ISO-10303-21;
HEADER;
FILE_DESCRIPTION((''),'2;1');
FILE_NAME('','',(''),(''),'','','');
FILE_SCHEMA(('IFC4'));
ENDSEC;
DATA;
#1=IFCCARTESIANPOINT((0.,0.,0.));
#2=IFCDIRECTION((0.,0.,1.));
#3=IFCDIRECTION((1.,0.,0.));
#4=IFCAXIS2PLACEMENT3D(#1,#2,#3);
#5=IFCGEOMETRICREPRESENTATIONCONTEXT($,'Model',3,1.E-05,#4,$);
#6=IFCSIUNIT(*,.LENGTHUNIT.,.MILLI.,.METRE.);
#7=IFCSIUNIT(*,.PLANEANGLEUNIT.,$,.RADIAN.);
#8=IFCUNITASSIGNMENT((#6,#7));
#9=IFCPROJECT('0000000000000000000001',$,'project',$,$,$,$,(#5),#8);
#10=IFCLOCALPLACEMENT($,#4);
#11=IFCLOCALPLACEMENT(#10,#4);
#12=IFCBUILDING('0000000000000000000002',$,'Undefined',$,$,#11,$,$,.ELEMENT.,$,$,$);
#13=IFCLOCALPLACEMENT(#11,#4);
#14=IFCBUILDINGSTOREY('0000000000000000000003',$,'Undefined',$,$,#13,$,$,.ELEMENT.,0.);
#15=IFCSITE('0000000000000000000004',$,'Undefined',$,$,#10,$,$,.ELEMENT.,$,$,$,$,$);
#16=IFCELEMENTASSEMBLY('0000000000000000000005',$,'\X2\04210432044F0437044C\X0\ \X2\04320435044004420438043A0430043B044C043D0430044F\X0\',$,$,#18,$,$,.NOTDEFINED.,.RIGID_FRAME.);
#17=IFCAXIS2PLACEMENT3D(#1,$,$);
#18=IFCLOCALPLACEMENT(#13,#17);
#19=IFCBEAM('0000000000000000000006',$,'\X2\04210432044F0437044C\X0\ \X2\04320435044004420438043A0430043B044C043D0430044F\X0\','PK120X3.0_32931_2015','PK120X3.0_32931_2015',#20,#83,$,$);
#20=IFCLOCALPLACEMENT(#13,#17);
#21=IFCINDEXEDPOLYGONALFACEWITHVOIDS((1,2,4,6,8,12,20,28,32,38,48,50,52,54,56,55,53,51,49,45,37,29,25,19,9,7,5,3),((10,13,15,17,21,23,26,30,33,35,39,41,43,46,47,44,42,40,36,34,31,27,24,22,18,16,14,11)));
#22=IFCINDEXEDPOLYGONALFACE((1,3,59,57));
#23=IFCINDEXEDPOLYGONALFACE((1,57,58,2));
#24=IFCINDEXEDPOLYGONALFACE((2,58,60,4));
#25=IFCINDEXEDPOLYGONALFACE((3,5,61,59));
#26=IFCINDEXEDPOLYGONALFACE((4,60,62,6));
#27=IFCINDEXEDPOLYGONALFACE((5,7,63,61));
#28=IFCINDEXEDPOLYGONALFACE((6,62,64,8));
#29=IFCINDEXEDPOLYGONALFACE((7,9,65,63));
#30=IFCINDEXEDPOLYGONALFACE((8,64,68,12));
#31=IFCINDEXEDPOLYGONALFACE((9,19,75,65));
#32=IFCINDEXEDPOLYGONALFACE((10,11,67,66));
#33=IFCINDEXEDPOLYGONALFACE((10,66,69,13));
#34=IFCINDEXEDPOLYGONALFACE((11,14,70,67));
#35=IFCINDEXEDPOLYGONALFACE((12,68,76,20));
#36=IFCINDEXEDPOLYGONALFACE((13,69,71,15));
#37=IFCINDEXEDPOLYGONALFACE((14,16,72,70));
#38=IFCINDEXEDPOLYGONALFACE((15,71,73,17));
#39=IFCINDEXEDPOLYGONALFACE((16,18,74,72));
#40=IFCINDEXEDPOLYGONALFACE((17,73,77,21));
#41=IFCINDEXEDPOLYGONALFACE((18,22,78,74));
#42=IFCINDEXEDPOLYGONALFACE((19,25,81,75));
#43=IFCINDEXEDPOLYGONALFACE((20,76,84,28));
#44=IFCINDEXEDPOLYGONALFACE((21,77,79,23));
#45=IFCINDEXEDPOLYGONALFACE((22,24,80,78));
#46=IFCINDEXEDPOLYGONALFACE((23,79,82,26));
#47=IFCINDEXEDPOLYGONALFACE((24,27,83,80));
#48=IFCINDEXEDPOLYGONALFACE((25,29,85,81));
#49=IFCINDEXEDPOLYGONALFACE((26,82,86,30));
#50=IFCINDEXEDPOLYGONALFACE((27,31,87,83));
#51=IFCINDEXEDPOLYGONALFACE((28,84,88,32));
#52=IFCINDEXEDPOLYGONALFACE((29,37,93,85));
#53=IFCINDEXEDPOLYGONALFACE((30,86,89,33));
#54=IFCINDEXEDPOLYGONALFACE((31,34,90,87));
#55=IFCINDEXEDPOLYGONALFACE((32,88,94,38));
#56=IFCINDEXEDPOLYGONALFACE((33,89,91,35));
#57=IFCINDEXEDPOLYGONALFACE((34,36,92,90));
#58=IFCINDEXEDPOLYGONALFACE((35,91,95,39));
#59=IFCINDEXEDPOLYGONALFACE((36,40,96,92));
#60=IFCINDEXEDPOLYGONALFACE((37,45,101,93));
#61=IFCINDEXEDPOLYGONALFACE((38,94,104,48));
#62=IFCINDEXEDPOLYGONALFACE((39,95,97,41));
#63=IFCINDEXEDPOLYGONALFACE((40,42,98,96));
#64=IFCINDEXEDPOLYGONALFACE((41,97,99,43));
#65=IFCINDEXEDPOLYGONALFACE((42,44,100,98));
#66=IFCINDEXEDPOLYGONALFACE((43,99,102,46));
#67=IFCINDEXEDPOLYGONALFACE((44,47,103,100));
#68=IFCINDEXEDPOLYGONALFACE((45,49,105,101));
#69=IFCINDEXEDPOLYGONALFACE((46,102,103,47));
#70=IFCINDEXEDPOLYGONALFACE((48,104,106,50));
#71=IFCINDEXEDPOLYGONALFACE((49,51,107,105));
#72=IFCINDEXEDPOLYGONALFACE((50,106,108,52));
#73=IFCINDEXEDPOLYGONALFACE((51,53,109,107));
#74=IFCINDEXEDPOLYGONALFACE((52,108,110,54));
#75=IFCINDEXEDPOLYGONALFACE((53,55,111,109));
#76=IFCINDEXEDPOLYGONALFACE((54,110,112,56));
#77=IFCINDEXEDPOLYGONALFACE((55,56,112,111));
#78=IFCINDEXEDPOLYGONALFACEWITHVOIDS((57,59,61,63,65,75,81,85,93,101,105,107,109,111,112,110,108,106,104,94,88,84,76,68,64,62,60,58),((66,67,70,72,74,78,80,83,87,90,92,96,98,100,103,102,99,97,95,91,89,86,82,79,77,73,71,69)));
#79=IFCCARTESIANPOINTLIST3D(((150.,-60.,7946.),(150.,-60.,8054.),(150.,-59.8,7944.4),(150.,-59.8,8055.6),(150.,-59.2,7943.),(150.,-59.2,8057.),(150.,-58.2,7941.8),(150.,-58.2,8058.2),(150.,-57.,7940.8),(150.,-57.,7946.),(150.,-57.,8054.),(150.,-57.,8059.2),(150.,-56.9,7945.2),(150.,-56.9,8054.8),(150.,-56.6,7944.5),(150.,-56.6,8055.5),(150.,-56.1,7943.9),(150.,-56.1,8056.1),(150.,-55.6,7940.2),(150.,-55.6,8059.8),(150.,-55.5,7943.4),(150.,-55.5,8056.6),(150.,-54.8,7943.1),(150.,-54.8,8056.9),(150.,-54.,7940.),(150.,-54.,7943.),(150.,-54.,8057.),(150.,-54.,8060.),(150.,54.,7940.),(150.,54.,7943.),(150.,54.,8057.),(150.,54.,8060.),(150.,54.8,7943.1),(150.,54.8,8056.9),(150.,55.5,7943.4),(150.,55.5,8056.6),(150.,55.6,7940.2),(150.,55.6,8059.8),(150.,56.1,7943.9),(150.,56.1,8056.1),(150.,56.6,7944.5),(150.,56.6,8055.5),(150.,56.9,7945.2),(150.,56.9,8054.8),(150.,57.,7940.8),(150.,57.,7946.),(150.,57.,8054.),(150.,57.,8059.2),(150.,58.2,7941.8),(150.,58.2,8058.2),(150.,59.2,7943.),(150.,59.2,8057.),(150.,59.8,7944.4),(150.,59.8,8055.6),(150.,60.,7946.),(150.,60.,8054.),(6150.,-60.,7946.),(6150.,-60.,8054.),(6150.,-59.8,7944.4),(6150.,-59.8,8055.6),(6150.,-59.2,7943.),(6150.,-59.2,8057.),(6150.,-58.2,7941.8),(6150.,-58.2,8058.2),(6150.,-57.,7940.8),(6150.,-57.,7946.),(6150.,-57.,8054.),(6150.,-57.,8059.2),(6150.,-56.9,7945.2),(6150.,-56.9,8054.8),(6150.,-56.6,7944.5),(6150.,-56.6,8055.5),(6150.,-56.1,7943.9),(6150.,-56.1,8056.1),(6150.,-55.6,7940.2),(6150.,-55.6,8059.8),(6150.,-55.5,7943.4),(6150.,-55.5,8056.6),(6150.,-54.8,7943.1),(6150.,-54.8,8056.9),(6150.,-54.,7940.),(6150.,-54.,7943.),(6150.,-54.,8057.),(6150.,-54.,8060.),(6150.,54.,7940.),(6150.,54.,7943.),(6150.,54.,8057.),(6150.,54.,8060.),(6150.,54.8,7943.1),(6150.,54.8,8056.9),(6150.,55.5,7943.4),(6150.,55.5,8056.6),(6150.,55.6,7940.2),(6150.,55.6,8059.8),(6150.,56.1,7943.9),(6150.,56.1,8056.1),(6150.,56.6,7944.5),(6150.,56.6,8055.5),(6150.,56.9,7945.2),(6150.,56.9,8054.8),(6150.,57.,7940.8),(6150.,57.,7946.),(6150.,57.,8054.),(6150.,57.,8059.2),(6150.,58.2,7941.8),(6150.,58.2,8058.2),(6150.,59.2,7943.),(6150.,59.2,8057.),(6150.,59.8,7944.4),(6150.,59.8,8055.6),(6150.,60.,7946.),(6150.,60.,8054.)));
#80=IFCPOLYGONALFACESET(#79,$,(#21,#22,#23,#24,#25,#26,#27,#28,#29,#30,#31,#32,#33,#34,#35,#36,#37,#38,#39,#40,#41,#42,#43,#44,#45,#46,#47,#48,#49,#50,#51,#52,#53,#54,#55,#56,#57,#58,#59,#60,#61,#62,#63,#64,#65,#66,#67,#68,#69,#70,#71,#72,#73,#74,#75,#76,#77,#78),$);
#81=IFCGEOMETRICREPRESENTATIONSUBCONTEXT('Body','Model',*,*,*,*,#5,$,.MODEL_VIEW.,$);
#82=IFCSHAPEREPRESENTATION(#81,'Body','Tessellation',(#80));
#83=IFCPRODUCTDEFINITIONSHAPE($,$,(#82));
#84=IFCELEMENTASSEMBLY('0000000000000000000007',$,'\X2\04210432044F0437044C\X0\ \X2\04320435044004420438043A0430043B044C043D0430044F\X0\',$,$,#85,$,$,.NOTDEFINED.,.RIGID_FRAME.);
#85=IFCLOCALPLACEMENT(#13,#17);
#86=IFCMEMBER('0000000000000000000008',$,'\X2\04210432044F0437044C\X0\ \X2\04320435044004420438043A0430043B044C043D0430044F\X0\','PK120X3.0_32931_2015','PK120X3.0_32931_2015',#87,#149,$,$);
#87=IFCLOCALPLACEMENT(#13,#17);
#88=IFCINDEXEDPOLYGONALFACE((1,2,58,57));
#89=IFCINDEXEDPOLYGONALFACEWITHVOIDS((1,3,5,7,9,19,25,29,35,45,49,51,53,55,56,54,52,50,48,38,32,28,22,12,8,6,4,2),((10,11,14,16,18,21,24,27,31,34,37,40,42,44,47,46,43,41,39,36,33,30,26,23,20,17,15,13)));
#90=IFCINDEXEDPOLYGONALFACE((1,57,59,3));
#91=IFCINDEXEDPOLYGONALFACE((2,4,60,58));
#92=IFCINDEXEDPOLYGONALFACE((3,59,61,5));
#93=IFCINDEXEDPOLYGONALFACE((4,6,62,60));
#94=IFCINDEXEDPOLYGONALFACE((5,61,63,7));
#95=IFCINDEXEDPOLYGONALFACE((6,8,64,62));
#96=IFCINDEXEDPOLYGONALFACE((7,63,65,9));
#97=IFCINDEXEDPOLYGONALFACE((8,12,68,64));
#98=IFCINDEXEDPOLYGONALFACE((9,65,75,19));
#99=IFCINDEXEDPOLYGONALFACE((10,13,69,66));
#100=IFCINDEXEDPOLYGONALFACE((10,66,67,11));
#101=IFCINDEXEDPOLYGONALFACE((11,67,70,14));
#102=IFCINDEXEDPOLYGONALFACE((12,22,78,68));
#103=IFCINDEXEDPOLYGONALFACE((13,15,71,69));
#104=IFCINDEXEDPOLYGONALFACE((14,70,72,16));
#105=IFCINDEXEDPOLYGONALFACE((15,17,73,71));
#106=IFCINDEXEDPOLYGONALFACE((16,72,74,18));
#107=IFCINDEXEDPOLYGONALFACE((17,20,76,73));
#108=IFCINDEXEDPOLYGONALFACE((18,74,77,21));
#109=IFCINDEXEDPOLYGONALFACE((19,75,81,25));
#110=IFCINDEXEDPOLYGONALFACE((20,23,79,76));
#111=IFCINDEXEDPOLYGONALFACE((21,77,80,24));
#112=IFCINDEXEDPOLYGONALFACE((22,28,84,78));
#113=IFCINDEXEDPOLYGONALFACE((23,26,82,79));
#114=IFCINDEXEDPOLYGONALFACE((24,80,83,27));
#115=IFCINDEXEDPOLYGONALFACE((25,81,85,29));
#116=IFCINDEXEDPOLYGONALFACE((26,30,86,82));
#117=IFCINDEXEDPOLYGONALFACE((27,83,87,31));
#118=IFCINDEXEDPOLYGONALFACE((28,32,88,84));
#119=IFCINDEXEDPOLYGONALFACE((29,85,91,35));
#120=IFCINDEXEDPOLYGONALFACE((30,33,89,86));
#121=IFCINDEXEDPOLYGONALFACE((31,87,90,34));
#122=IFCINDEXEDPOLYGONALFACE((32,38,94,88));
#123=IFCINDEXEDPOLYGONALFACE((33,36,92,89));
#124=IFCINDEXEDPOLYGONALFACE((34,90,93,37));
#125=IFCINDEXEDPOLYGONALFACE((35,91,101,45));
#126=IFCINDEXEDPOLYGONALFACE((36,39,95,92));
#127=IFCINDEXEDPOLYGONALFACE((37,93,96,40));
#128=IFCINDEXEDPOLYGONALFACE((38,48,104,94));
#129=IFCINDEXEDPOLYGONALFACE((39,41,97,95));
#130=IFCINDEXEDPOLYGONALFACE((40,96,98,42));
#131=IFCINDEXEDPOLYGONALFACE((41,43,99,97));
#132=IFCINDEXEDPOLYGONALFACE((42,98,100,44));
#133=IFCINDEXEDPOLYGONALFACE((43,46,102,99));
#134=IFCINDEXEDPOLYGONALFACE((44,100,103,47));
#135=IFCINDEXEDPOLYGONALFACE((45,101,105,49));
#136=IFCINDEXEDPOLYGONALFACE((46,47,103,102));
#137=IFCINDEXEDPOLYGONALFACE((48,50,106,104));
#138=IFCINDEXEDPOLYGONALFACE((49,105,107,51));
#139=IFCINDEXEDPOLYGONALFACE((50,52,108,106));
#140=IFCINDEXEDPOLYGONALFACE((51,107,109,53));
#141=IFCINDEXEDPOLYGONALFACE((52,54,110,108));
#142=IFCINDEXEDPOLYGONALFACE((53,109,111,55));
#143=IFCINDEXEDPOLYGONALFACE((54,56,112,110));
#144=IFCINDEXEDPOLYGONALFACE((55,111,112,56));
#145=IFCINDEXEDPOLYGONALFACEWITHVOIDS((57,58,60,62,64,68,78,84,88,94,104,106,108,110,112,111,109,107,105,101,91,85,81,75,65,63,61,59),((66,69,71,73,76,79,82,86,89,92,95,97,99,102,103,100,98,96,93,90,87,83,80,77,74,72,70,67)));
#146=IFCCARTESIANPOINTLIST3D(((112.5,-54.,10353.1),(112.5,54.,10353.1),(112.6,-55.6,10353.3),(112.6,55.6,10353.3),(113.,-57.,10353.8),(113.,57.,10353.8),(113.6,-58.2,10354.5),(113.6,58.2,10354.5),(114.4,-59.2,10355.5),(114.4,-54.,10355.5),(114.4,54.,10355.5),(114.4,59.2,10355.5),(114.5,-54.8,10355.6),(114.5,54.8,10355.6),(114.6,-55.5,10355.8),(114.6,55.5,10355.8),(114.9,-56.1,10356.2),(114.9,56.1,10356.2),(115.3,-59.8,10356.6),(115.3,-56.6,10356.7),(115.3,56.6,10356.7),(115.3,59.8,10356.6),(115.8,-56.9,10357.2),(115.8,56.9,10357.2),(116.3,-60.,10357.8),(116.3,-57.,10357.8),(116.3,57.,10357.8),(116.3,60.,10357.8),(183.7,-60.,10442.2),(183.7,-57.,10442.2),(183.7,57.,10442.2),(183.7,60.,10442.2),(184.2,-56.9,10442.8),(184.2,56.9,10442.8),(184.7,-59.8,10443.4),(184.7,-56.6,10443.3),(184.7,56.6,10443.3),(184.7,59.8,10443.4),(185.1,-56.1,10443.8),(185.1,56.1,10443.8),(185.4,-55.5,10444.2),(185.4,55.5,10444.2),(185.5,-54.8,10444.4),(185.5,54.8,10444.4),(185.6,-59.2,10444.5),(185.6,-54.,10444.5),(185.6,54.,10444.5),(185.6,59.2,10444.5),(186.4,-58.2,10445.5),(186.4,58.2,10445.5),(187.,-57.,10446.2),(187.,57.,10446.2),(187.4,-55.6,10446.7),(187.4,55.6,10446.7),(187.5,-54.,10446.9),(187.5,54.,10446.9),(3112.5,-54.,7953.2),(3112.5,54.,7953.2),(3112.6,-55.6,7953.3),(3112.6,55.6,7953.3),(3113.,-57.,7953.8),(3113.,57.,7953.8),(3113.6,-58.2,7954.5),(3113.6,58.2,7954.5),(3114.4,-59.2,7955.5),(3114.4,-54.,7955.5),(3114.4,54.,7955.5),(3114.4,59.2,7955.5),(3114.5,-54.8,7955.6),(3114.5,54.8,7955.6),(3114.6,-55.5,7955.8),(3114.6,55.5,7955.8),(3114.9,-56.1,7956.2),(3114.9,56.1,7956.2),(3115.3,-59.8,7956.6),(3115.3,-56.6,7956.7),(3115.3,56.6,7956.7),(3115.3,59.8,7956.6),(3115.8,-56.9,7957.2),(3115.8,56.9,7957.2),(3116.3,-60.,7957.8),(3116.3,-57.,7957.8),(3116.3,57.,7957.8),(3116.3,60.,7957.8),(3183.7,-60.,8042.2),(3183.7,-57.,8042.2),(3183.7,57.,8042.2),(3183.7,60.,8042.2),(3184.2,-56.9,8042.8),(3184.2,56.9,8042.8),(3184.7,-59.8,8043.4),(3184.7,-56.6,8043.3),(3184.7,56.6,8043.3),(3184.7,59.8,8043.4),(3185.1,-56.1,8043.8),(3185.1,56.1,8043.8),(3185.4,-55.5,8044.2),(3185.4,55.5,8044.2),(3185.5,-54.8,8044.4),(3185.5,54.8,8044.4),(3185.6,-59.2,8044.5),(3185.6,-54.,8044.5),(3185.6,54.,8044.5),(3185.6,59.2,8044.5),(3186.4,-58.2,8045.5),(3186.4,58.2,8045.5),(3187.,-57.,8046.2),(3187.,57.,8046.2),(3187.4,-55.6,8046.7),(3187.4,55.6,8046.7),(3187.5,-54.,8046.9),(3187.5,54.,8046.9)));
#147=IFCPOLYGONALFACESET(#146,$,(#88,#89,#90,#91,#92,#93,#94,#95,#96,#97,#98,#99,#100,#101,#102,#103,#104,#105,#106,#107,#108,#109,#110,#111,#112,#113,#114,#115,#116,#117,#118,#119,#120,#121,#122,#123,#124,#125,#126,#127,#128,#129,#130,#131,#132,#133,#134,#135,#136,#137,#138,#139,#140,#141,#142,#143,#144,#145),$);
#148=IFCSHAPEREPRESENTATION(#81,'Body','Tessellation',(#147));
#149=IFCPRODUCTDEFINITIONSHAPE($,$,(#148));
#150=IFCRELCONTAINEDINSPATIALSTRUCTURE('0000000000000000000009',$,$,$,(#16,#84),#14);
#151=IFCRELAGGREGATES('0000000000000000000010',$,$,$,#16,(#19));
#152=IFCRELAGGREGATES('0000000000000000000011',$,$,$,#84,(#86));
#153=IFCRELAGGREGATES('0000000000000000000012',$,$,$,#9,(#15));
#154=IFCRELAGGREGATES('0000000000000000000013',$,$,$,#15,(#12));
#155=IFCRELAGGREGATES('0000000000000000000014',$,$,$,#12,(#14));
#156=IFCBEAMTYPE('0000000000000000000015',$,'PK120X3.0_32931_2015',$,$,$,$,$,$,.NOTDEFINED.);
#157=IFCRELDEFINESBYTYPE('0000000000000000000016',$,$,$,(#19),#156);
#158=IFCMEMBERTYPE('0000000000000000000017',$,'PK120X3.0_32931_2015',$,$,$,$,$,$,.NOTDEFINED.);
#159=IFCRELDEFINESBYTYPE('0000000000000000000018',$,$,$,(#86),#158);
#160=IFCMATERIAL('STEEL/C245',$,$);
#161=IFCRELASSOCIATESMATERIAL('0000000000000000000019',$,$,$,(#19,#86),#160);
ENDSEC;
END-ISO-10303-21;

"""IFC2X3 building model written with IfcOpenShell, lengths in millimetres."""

from ifc_helpers import new_model, si_unit, frame, origin_with_axes, origin_2d_with_axis, place, context, subcontext, project, spatial, hollow_rectangle, extrude, material, type_object, element, aggregate, save


model = new_model("IFC2X3")

# Units and contexts
model_context = context("Model", 3, precision=1e-05, world=origin_with_axes())
body_context = subcontext(model_context, "Body", "Model", "MODEL_VIEW")
ifc_project = project(units=[si_unit("LENGTHUNIT", "METRE", prefix="MILLI"), si_unit("PLANEANGLEUNIT", "RADIAN")], contexts=[model_context])

# Site, building, storey
site_placement = place(None, origin_with_axes())
site = spatial("IfcSite", under=ifc_project, at=site_placement, Name="Undefined", CompositionType="ELEMENT")
building_placement = place(site_placement, origin_with_axes())
building = spatial("IfcBuilding", under=site, at=building_placement, Name="Undefined", CompositionType="ELEMENT")
storey_placement = place(building_placement, origin_with_axes())
storey = spatial("IfcBuildingStorey", under=building, at=storey_placement, Name="Undefined", CompositionType="ELEMENT", Elevation=0.0)

# Shared definitions
ifc_material_1 = material(Name="STEEL/C245")

# Element assembly, beam
beam_type_1 = type_object("IfcBeamType", Name="PK120X3.0_32931_2015", PredefinedType="NOTDEFINED")
assembly_1_placement = place(storey_placement, origin_with_axes())
assembly_1 = element("IfcElementAssembly", 1, at=assembly_1_placement, inside=storey, Name="Связь вертикальная", AssemblyPlace="NOTDEFINED", PredefinedType="RIGID_FRAME")
beam_1_placement = place(assembly_1_placement, frame((150.0, 0.0, 8000.0), z_axis=(0.0, 0.0, 1.0), x_axis=(1.0, 0.0, 0.0)))
beam_1 = element("IfcBeam", 2, at=beam_1_placement, type_object=beam_type_1, material=ifc_material_1, Name="Связь вертикальная", Description="PK120X3.0_32931_2015", ObjectType="PK120X3.0_32931_2015", context=body_context, shape_type="SweptSolid", body=[
    extrude(hollow_rectangle(XDim=120.0, YDim=120.0, WallThickness=3.0, InnerFilletRadius=3.0, OuterFilletRadius=6.0, at=origin_2d_with_axis()), frame((6000.0, 0.0, 0.0), z_axis=(-1.0, 0.0, 0.0), x_axis=(0.0, -1.0, 0.0)), (0.0, 0.0, 1.0), 6000.0),
])
aggregate(assembly_1, [beam_1])

# Element assembly, member
assembly_2_placement = place(storey_placement, origin_with_axes())
assembly_2 = element("IfcElementAssembly", 3, at=assembly_2_placement, inside=storey, Name="Связь вертикальная", AssemblyPlace="NOTDEFINED", PredefinedType="RIGID_FRAME")
member_type = type_object("IfcMemberType", Name="PK120X3.0_32931_2015", PredefinedType="NOTDEFINED")
member_1_placement = place(assembly_2_placement, frame((3150.0, 0.0, 8000.0), z_axis=(0.624695, 0.0, 0.780869), x_axis=(-0.780869, 0.0, 0.624695)))
member_1 = element("IfcMember", 4, at=member_1_placement, type_object=member_type, material=ifc_material_1, Name="Связь вертикальная", Description="PK120X3.0_32931_2015", ObjectType="PK120X3.0_32931_2015", context=body_context, shape_type="SweptSolid", body=[
    extrude(hollow_rectangle(XDim=120.0, YDim=120.0, WallThickness=3.0, InnerFilletRadius=3.0, OuterFilletRadius=6.0, at=origin_2d_with_axis()), frame((3841.9, 0.0, 0.0), z_axis=(-1.0, 0.0, 0.0), x_axis=(0.0, -1.0, 0.0)), (0.0, 0.0, 1.0), 3841.9),
])
aggregate(assembly_2, [member_1])

save(model, "model.ifc")
